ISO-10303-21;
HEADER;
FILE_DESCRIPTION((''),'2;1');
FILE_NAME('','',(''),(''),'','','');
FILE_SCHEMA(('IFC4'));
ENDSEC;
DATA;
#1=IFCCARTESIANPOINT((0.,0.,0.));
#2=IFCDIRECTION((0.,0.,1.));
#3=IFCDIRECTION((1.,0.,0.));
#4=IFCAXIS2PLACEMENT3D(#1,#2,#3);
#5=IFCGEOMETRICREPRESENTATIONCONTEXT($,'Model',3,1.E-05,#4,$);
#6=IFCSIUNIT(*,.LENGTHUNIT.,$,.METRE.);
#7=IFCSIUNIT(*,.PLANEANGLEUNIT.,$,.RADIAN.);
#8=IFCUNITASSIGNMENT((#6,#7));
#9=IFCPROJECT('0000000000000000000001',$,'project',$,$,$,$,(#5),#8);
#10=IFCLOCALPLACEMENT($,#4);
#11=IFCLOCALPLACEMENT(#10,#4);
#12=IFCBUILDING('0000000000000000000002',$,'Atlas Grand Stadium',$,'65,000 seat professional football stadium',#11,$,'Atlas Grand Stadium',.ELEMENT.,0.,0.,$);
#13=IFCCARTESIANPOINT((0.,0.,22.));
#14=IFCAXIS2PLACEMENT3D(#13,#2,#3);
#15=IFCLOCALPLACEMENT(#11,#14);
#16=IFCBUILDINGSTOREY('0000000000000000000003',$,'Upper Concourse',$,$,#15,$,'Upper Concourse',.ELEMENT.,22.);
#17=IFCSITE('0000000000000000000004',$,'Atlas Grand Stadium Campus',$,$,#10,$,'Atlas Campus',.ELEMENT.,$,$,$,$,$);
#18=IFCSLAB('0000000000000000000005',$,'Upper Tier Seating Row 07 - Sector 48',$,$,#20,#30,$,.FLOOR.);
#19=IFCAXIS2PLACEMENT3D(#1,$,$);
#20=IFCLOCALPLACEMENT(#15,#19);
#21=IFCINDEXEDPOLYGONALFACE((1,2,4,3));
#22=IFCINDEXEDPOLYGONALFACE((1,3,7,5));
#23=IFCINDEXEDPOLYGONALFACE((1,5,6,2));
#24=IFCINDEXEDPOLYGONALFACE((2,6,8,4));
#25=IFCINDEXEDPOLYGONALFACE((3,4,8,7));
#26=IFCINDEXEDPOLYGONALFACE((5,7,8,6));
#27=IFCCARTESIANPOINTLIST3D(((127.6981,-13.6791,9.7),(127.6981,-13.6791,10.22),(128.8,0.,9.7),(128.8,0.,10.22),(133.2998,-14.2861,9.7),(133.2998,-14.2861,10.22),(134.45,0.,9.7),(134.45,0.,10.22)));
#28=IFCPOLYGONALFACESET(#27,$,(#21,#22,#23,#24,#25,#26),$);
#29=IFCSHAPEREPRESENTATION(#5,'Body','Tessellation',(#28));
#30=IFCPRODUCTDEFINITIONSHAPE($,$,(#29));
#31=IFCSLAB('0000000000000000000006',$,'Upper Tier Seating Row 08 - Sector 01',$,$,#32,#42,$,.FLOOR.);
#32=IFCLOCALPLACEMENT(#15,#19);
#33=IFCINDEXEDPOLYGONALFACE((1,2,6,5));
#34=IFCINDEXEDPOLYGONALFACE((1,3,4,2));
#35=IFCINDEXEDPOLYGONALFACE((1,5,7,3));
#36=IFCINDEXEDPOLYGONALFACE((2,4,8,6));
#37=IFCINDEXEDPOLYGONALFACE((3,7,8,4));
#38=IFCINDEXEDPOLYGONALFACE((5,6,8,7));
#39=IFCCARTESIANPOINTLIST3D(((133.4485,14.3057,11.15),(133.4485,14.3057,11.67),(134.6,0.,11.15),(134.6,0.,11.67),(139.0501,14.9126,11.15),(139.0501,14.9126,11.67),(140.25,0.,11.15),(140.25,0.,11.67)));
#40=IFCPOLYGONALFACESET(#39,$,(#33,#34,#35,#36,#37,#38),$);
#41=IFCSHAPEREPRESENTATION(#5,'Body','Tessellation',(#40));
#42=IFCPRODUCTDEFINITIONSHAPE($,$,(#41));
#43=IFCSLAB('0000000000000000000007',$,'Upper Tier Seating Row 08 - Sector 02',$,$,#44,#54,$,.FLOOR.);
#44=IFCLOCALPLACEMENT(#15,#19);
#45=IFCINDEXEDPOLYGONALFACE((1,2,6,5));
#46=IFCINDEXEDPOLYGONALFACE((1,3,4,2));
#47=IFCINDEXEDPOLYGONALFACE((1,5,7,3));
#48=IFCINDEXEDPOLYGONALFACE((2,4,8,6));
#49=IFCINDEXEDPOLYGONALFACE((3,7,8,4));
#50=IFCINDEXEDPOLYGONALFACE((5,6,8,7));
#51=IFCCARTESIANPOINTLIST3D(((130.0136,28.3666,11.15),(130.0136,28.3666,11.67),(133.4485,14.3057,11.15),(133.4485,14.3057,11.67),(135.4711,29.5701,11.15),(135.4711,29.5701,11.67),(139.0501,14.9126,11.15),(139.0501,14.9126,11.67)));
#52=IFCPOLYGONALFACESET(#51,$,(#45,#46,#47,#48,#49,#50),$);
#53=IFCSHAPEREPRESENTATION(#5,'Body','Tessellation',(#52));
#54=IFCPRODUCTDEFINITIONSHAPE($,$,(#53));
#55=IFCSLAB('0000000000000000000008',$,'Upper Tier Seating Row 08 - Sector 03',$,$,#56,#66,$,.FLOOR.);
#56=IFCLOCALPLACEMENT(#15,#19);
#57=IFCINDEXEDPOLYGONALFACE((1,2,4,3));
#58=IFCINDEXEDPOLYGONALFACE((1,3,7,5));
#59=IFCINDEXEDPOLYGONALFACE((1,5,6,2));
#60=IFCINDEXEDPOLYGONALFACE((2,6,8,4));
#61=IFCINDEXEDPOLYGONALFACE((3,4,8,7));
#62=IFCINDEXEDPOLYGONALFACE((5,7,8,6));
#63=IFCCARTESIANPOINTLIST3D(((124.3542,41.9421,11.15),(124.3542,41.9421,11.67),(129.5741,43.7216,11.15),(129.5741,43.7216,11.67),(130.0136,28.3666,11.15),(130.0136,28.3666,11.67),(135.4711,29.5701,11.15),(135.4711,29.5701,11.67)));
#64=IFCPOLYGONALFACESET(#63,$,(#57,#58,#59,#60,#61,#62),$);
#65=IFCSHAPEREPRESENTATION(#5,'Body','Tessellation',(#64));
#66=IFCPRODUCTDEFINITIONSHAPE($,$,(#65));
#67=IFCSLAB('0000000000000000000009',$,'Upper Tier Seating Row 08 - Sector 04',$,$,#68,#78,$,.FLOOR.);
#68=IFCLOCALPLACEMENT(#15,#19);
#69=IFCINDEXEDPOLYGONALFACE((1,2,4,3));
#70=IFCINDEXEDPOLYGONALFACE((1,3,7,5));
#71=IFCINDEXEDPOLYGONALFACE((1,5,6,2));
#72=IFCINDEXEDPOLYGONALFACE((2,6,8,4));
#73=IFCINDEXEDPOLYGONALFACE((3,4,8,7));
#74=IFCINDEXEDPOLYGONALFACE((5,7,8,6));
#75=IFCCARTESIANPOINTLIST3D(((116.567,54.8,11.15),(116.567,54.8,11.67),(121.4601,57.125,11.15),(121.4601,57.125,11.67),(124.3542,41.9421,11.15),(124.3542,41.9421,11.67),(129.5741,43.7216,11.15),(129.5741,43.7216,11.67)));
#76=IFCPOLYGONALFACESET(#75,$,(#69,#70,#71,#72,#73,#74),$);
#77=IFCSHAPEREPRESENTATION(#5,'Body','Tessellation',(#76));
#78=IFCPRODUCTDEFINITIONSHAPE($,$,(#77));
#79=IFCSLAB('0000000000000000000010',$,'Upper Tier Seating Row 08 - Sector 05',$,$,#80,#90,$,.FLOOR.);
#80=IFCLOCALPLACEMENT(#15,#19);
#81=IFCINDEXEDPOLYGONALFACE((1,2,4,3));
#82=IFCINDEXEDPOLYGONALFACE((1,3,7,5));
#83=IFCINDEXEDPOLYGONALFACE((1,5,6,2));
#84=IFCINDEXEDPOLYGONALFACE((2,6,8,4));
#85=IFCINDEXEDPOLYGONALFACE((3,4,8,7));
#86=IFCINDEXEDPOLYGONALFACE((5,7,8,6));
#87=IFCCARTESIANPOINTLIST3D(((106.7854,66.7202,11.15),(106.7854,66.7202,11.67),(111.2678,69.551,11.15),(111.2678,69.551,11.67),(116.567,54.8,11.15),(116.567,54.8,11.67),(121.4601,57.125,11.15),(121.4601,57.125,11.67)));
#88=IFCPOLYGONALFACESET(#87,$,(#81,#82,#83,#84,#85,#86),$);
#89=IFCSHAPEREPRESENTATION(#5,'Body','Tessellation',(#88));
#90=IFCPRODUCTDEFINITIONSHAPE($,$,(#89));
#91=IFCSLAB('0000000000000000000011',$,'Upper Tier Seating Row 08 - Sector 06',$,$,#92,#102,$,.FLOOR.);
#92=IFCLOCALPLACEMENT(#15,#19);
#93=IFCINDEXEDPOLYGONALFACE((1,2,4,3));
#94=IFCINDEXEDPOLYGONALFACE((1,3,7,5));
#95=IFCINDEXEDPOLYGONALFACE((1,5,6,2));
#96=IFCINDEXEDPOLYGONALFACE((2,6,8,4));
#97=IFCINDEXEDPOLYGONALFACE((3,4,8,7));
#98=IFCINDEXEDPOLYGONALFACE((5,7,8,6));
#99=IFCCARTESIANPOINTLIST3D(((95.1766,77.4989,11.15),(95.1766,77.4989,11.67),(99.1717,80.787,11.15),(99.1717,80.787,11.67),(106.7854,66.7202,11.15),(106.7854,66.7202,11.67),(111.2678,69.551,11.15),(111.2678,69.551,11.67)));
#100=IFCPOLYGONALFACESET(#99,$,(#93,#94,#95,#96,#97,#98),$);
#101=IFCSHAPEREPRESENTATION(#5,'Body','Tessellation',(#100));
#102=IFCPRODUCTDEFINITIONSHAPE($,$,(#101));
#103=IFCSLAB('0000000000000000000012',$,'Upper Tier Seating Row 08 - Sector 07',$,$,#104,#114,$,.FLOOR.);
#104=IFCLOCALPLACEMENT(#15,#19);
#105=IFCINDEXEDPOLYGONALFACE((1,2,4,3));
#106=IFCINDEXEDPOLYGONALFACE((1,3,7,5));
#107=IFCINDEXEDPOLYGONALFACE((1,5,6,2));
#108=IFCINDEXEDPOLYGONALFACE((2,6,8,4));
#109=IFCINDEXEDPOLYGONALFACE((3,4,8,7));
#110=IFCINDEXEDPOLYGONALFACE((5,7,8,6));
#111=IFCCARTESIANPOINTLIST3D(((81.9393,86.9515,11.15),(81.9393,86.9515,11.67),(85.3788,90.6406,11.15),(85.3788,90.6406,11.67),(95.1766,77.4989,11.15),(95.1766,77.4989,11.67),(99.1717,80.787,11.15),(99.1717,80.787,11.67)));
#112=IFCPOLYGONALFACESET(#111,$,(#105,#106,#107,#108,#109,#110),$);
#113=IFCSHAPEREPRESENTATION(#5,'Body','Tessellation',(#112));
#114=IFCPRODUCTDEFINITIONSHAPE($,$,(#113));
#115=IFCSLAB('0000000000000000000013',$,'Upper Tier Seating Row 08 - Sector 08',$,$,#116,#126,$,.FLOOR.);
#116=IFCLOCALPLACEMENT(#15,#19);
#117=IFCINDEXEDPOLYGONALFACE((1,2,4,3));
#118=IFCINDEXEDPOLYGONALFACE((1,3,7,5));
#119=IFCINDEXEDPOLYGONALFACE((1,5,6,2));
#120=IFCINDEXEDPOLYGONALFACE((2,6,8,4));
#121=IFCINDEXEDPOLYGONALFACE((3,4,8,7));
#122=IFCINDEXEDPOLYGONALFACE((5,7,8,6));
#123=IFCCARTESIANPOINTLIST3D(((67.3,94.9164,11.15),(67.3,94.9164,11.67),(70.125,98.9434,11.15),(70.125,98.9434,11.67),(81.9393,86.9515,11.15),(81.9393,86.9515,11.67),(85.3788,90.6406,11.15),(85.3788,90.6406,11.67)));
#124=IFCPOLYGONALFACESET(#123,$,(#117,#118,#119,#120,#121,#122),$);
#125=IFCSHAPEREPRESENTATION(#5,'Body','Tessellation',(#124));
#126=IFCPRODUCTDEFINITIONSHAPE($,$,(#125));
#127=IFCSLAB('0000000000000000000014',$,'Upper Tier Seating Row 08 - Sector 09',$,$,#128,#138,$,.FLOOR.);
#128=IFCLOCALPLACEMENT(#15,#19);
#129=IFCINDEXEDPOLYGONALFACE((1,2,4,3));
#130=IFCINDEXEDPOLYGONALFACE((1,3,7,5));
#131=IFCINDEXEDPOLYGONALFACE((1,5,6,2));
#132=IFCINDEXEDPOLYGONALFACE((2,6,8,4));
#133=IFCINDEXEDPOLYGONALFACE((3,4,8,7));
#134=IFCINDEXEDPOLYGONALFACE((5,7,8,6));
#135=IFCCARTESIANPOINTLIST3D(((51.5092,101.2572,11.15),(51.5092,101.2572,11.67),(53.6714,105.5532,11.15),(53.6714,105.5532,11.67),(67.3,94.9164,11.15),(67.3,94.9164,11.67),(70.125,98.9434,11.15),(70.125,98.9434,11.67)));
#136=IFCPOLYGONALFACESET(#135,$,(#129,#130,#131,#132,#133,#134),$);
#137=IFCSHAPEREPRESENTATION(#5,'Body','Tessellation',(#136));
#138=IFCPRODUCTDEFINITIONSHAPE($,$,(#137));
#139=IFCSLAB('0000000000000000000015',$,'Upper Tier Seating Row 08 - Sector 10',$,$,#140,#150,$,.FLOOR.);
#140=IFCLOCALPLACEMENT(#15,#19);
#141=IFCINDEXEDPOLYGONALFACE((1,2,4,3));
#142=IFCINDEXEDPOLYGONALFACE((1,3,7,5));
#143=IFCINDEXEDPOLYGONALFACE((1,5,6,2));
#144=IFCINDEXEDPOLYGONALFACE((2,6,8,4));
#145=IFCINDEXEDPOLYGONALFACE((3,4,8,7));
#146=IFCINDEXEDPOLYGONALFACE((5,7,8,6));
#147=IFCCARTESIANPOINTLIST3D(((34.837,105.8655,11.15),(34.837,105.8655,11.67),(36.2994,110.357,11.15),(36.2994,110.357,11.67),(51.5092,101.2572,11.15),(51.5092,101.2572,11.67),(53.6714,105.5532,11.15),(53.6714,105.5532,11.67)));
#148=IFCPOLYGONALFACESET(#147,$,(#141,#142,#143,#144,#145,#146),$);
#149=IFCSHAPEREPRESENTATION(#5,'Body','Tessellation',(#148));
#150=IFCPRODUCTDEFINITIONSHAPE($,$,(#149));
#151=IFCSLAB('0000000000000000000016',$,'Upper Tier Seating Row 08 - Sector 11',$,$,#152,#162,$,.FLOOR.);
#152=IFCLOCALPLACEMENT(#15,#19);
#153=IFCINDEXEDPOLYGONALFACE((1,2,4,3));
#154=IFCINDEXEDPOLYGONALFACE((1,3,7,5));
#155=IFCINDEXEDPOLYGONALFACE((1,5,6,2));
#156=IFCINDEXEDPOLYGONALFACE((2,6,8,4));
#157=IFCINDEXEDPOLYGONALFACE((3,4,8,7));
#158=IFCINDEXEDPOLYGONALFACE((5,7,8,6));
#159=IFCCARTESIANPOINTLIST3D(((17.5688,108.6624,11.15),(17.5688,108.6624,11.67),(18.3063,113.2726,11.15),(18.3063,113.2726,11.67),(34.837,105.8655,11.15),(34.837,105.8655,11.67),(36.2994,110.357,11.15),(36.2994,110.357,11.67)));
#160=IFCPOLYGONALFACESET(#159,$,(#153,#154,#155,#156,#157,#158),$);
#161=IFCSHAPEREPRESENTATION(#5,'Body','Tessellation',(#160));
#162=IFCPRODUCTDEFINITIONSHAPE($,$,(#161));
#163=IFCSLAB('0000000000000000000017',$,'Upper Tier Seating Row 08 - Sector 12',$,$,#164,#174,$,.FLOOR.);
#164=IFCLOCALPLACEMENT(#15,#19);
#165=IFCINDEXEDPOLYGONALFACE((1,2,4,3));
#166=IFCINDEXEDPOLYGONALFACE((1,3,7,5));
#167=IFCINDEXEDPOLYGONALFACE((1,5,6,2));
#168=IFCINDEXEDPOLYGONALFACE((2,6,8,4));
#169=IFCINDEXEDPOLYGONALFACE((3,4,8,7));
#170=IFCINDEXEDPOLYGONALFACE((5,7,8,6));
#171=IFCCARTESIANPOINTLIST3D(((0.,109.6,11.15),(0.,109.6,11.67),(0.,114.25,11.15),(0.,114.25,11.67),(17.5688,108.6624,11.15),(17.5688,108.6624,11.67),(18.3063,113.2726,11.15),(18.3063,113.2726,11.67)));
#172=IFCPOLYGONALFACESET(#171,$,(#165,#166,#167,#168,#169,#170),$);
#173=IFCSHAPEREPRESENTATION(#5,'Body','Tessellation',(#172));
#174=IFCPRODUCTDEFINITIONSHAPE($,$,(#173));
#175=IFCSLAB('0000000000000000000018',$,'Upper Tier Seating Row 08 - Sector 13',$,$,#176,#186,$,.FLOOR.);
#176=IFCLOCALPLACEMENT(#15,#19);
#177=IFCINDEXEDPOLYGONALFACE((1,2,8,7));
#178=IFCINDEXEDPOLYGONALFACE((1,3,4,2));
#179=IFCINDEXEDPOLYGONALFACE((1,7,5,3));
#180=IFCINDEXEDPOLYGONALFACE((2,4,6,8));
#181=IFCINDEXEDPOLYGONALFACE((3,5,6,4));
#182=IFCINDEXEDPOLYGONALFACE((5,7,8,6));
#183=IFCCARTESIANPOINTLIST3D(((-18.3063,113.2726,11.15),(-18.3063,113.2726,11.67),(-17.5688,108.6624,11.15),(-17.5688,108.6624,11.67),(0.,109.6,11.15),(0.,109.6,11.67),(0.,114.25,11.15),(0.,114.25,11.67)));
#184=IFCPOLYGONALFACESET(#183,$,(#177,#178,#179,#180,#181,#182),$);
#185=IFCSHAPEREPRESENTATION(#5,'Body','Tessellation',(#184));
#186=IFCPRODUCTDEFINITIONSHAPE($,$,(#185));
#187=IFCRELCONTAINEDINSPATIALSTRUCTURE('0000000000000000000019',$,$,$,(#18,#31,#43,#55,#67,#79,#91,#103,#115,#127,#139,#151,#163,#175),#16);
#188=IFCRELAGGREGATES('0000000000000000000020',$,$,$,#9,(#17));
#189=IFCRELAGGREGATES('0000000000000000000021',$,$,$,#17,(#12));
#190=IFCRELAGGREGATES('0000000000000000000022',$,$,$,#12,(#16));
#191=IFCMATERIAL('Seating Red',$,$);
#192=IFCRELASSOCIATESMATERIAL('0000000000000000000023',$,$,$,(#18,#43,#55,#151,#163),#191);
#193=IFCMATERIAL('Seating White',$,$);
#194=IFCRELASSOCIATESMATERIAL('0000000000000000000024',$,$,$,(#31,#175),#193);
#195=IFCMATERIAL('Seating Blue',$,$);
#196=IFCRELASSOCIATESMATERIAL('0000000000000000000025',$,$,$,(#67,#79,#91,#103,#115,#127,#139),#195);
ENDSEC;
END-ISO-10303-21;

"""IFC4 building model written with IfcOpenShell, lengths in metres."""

from ifc_helpers import new_model, si_unit, frame, origin_with_axes, place, context, project, spatial, polyline, outline, extrude, material, element, save


model = new_model("IFC4")

# Units and contexts
model_context = context("Model", 3, precision=1e-05, world=origin_with_axes())
ifc_project = project(units=[si_unit("LENGTHUNIT", "METRE"), si_unit("PLANEANGLEUNIT", "RADIAN")], contexts=[model_context])

# Site, building, storey
site_placement = place(None, origin_with_axes())
site = spatial("IfcSite", under=ifc_project, at=site_placement, Name="Atlas Grand Stadium Campus", LongName="Atlas Campus", CompositionType="ELEMENT")
building_placement = place(site_placement, origin_with_axes())
building = spatial("IfcBuilding", under=site, at=building_placement, Name="Atlas Grand Stadium", ObjectType="65,000 seat professional football stadium", LongName="Atlas Grand Stadium", CompositionType="ELEMENT", ElevationOfRefHeight=0.0, ElevationOfTerrain=0.0)
storey_placement = place(building_placement, frame((0.0, 0.0, 22.0), z_axis=(0.0, 0.0, 1.0), x_axis=(1.0, 0.0, 0.0)))
storey = spatial("IfcBuildingStorey", under=building, at=storey_placement, Name="Upper Concourse", LongName="Upper Concourse", CompositionType="ELEMENT", Elevation=22.0)

# Slabs
ifc_material_1 = material(Name="Seating Red")
slab_1_placement = place(storey_placement, frame((0.0, 0.0, 9.7), z_axis=(0.0, 0.0, 1.0), x_axis=(1.0, 0.0, 0.0)))
element("IfcSlab", 1, at=slab_1_placement, inside=storey, material=ifc_material_1, Name="Upper Tier Seating Row 07 - Sector 48", PredefinedType="FLOOR", context=model_context, shape_type="SweptSolid", body=[
    extrude(outline(polyline([(133.2998, -14.2861), (134.45, 0.0), (128.8, 0.0), (127.6981, -13.6791), (133.2998, -14.2861)])), origin_with_axes(), (0.0, 0.0, 1.0), 0.52),
])
ifc_material_2 = material(Name="Seating White")
slab_2_placement = place(storey_placement, frame((0.0, 0.0, 11.15), z_axis=(0.0, 0.0, 1.0), x_axis=(1.0, 0.0, 0.0)))
element("IfcSlab", 2, at=slab_2_placement, inside=storey, material=ifc_material_2, Name="Upper Tier Seating Row 08 - Sector 01", PredefinedType="FLOOR", context=model_context, shape_type="SweptSolid", body=[
    extrude(outline(polyline([(140.25, 0.0), (139.0501, 14.9126), (133.4485, 14.3057), (134.6, 0.0), (140.25, 0.0)])), origin_with_axes(), (0.0, 0.0, 1.0), 0.52),
])
slab_3_placement = place(storey_placement, frame((0.0, 0.0, 11.15), z_axis=(0.0, 0.0, 1.0), x_axis=(1.0, 0.0, 0.0)))
element("IfcSlab", 3, at=slab_3_placement, inside=storey, material=ifc_material_1, Name="Upper Tier Seating Row 08 - Sector 02", PredefinedType="FLOOR", context=model_context, shape_type="SweptSolid", body=[
    extrude(outline(polyline([(139.0501, 14.9126), (135.4711, 29.5701), (130.0136, 28.3666), (133.4485, 14.3057), (139.0501, 14.9126)])), origin_with_axes(), (0.0, 0.0, 1.0), 0.52),
])
slab_4_placement = place(storey_placement, frame((0.0, 0.0, 11.15), z_axis=(0.0, 0.0, 1.0), x_axis=(1.0, 0.0, 0.0)))
element("IfcSlab", 4, at=slab_4_placement, inside=storey, material=ifc_material_1, Name="Upper Tier Seating Row 08 - Sector 03", PredefinedType="FLOOR", context=model_context, shape_type="SweptSolid", body=[
    extrude(outline(polyline([(135.4711, 29.5701), (129.5741, 43.7216), (124.3542, 41.9421), (130.0136, 28.3666), (135.4711, 29.5701)])), origin_with_axes(), (0.0, 0.0, 1.0), 0.52),
])
ifc_material_3 = material(Name="Seating Blue")
slab_5_placement = place(storey_placement, frame((0.0, 0.0, 11.15), z_axis=(0.0, 0.0, 1.0), x_axis=(1.0, 0.0, 0.0)))
element("IfcSlab", 5, at=slab_5_placement, inside=storey, material=ifc_material_3, Name="Upper Tier Seating Row 08 - Sector 04", PredefinedType="FLOOR", context=model_context, shape_type="SweptSolid", body=[
    extrude(outline(polyline([(129.5741, 43.7216), (121.4601, 57.125), (116.567, 54.8), (124.3542, 41.9421), (129.5741, 43.7216)])), origin_with_axes(), (0.0, 0.0, 1.0), 0.52),
])
slab_6_placement = place(storey_placement, frame((0.0, 0.0, 11.15), z_axis=(0.0, 0.0, 1.0), x_axis=(1.0, 0.0, 0.0)))
element("IfcSlab", 6, at=slab_6_placement, inside=storey, material=ifc_material_3, Name="Upper Tier Seating Row 08 - Sector 05", PredefinedType="FLOOR", context=model_context, shape_type="SweptSolid", body=[
    extrude(outline(polyline([(121.4601, 57.125), (111.2678, 69.551), (106.7854, 66.7202), (116.567, 54.8), (121.4601, 57.125)])), origin_with_axes(), (0.0, 0.0, 1.0), 0.52),
])
slab_7_placement = place(storey_placement, frame((0.0, 0.0, 11.15), z_axis=(0.0, 0.0, 1.0), x_axis=(1.0, 0.0, 0.0)))
element("IfcSlab", 7, at=slab_7_placement, inside=storey, material=ifc_material_3, Name="Upper Tier Seating Row 08 - Sector 06", PredefinedType="FLOOR", context=model_context, shape_type="SweptSolid", body=[
    extrude(outline(polyline([(111.2678, 69.551), (99.1717, 80.787), (95.1766, 77.4989), (106.7854, 66.7202), (111.2678, 69.551)])), origin_with_axes(), (0.0, 0.0, 1.0), 0.52),
])
slab_8_placement = place(storey_placement, frame((0.0, 0.0, 11.15), z_axis=(0.0, 0.0, 1.0), x_axis=(1.0, 0.0, 0.0)))
element("IfcSlab", 8, at=slab_8_placement, inside=storey, material=ifc_material_3, Name="Upper Tier Seating Row 08 - Sector 07", PredefinedType="FLOOR", context=model_context, shape_type="SweptSolid", body=[
    extrude(outline(polyline([(99.1717, 80.787), (85.3788, 90.6406), (81.9393, 86.9515), (95.1766, 77.4989), (99.1717, 80.787)])), origin_with_axes(), (0.0, 0.0, 1.0), 0.52),
])
slab_9_placement = place(storey_placement, frame((0.0, 0.0, 11.15), z_axis=(0.0, 0.0, 1.0), x_axis=(1.0, 0.0, 0.0)))
element("IfcSlab", 9, at=slab_9_placement, inside=storey, material=ifc_material_3, Name="Upper Tier Seating Row 08 - Sector 08", PredefinedType="FLOOR", context=model_context, shape_type="SweptSolid", body=[
    extrude(outline(polyline([(85.3788, 90.6406), (70.125, 98.9434), (67.3, 94.9164), (81.9393, 86.9515), (85.3788, 90.6406)])), origin_with_axes(), (0.0, 0.0, 1.0), 0.52),
])
slab_10_placement = place(storey_placement, frame((0.0, 0.0, 11.15), z_axis=(0.0, 0.0, 1.0), x_axis=(1.0, 0.0, 0.0)))
element("IfcSlab", 10, at=slab_10_placement, inside=storey, material=ifc_material_3, Name="Upper Tier Seating Row 08 - Sector 09", PredefinedType="FLOOR", context=model_context, shape_type="SweptSolid", body=[
    extrude(outline(polyline([(70.125, 98.9434), (53.6713, 105.5532), (51.5092, 101.2572), (67.3, 94.9164), (70.125, 98.9434)])), origin_with_axes(), (0.0, 0.0, 1.0), 0.52),
])
slab_11_placement = place(storey_placement, frame((0.0, 0.0, 11.15), z_axis=(0.0, 0.0, 1.0), x_axis=(1.0, 0.0, 0.0)))
element("IfcSlab", 11, at=slab_11_placement, inside=storey, material=ifc_material_3, Name="Upper Tier Seating Row 08 - Sector 10", PredefinedType="FLOOR", context=model_context, shape_type="SweptSolid", body=[
    extrude(outline(polyline([(53.6713, 105.5532), (36.2994, 110.357), (34.837, 105.8655), (51.5092, 101.2572), (53.6713, 105.5532)])), origin_with_axes(), (0.0, 0.0, 1.0), 0.52),
])
slab_12_placement = place(storey_placement, frame((0.0, 0.0, 11.15), z_axis=(0.0, 0.0, 1.0), x_axis=(1.0, 0.0, 0.0)))
element("IfcSlab", 12, at=slab_12_placement, inside=storey, material=ifc_material_1, Name="Upper Tier Seating Row 08 - Sector 11", PredefinedType="FLOOR", context=model_context, shape_type="SweptSolid", body=[
    extrude(outline(polyline([(36.2994, 110.357), (18.3063, 113.2726), (17.5688, 108.6624), (34.837, 105.8655), (36.2994, 110.357)])), origin_with_axes(), (0.0, 0.0, 1.0), 0.52),
])
slab_13_placement = place(storey_placement, frame((0.0, 0.0, 11.15), z_axis=(0.0, 0.0, 1.0), x_axis=(1.0, 0.0, 0.0)))
element("IfcSlab", 13, at=slab_13_placement, inside=storey, material=ifc_material_1, Name="Upper Tier Seating Row 08 - Sector 12", PredefinedType="FLOOR", context=model_context, shape_type="SweptSolid", body=[
    extrude(outline(polyline([(18.3063, 113.2726), (0.0, 114.25), (0.0, 109.6), (17.5688, 108.6624), (18.3063, 113.2726)])), origin_with_axes(), (0.0, 0.0, 1.0), 0.52),
])
slab_14_placement = place(storey_placement, frame((0.0, 0.0, 11.15), z_axis=(0.0, 0.0, 1.0), x_axis=(1.0, 0.0, 0.0)))
element("IfcSlab", 14, at=slab_14_placement, inside=storey, material=ifc_material_2, Name="Upper Tier Seating Row 08 - Sector 13", PredefinedType="FLOOR", context=model_context, shape_type="SweptSolid", body=[
    extrude(outline(polyline([(0.0, 114.25), (-18.3063, 113.2726), (-17.5688, 108.6624), (0.0, 109.6), (0.0, 114.25)])), origin_with_axes(), (0.0, 0.0, 1.0), 0.52),
])

save(model, "model.ifc")
